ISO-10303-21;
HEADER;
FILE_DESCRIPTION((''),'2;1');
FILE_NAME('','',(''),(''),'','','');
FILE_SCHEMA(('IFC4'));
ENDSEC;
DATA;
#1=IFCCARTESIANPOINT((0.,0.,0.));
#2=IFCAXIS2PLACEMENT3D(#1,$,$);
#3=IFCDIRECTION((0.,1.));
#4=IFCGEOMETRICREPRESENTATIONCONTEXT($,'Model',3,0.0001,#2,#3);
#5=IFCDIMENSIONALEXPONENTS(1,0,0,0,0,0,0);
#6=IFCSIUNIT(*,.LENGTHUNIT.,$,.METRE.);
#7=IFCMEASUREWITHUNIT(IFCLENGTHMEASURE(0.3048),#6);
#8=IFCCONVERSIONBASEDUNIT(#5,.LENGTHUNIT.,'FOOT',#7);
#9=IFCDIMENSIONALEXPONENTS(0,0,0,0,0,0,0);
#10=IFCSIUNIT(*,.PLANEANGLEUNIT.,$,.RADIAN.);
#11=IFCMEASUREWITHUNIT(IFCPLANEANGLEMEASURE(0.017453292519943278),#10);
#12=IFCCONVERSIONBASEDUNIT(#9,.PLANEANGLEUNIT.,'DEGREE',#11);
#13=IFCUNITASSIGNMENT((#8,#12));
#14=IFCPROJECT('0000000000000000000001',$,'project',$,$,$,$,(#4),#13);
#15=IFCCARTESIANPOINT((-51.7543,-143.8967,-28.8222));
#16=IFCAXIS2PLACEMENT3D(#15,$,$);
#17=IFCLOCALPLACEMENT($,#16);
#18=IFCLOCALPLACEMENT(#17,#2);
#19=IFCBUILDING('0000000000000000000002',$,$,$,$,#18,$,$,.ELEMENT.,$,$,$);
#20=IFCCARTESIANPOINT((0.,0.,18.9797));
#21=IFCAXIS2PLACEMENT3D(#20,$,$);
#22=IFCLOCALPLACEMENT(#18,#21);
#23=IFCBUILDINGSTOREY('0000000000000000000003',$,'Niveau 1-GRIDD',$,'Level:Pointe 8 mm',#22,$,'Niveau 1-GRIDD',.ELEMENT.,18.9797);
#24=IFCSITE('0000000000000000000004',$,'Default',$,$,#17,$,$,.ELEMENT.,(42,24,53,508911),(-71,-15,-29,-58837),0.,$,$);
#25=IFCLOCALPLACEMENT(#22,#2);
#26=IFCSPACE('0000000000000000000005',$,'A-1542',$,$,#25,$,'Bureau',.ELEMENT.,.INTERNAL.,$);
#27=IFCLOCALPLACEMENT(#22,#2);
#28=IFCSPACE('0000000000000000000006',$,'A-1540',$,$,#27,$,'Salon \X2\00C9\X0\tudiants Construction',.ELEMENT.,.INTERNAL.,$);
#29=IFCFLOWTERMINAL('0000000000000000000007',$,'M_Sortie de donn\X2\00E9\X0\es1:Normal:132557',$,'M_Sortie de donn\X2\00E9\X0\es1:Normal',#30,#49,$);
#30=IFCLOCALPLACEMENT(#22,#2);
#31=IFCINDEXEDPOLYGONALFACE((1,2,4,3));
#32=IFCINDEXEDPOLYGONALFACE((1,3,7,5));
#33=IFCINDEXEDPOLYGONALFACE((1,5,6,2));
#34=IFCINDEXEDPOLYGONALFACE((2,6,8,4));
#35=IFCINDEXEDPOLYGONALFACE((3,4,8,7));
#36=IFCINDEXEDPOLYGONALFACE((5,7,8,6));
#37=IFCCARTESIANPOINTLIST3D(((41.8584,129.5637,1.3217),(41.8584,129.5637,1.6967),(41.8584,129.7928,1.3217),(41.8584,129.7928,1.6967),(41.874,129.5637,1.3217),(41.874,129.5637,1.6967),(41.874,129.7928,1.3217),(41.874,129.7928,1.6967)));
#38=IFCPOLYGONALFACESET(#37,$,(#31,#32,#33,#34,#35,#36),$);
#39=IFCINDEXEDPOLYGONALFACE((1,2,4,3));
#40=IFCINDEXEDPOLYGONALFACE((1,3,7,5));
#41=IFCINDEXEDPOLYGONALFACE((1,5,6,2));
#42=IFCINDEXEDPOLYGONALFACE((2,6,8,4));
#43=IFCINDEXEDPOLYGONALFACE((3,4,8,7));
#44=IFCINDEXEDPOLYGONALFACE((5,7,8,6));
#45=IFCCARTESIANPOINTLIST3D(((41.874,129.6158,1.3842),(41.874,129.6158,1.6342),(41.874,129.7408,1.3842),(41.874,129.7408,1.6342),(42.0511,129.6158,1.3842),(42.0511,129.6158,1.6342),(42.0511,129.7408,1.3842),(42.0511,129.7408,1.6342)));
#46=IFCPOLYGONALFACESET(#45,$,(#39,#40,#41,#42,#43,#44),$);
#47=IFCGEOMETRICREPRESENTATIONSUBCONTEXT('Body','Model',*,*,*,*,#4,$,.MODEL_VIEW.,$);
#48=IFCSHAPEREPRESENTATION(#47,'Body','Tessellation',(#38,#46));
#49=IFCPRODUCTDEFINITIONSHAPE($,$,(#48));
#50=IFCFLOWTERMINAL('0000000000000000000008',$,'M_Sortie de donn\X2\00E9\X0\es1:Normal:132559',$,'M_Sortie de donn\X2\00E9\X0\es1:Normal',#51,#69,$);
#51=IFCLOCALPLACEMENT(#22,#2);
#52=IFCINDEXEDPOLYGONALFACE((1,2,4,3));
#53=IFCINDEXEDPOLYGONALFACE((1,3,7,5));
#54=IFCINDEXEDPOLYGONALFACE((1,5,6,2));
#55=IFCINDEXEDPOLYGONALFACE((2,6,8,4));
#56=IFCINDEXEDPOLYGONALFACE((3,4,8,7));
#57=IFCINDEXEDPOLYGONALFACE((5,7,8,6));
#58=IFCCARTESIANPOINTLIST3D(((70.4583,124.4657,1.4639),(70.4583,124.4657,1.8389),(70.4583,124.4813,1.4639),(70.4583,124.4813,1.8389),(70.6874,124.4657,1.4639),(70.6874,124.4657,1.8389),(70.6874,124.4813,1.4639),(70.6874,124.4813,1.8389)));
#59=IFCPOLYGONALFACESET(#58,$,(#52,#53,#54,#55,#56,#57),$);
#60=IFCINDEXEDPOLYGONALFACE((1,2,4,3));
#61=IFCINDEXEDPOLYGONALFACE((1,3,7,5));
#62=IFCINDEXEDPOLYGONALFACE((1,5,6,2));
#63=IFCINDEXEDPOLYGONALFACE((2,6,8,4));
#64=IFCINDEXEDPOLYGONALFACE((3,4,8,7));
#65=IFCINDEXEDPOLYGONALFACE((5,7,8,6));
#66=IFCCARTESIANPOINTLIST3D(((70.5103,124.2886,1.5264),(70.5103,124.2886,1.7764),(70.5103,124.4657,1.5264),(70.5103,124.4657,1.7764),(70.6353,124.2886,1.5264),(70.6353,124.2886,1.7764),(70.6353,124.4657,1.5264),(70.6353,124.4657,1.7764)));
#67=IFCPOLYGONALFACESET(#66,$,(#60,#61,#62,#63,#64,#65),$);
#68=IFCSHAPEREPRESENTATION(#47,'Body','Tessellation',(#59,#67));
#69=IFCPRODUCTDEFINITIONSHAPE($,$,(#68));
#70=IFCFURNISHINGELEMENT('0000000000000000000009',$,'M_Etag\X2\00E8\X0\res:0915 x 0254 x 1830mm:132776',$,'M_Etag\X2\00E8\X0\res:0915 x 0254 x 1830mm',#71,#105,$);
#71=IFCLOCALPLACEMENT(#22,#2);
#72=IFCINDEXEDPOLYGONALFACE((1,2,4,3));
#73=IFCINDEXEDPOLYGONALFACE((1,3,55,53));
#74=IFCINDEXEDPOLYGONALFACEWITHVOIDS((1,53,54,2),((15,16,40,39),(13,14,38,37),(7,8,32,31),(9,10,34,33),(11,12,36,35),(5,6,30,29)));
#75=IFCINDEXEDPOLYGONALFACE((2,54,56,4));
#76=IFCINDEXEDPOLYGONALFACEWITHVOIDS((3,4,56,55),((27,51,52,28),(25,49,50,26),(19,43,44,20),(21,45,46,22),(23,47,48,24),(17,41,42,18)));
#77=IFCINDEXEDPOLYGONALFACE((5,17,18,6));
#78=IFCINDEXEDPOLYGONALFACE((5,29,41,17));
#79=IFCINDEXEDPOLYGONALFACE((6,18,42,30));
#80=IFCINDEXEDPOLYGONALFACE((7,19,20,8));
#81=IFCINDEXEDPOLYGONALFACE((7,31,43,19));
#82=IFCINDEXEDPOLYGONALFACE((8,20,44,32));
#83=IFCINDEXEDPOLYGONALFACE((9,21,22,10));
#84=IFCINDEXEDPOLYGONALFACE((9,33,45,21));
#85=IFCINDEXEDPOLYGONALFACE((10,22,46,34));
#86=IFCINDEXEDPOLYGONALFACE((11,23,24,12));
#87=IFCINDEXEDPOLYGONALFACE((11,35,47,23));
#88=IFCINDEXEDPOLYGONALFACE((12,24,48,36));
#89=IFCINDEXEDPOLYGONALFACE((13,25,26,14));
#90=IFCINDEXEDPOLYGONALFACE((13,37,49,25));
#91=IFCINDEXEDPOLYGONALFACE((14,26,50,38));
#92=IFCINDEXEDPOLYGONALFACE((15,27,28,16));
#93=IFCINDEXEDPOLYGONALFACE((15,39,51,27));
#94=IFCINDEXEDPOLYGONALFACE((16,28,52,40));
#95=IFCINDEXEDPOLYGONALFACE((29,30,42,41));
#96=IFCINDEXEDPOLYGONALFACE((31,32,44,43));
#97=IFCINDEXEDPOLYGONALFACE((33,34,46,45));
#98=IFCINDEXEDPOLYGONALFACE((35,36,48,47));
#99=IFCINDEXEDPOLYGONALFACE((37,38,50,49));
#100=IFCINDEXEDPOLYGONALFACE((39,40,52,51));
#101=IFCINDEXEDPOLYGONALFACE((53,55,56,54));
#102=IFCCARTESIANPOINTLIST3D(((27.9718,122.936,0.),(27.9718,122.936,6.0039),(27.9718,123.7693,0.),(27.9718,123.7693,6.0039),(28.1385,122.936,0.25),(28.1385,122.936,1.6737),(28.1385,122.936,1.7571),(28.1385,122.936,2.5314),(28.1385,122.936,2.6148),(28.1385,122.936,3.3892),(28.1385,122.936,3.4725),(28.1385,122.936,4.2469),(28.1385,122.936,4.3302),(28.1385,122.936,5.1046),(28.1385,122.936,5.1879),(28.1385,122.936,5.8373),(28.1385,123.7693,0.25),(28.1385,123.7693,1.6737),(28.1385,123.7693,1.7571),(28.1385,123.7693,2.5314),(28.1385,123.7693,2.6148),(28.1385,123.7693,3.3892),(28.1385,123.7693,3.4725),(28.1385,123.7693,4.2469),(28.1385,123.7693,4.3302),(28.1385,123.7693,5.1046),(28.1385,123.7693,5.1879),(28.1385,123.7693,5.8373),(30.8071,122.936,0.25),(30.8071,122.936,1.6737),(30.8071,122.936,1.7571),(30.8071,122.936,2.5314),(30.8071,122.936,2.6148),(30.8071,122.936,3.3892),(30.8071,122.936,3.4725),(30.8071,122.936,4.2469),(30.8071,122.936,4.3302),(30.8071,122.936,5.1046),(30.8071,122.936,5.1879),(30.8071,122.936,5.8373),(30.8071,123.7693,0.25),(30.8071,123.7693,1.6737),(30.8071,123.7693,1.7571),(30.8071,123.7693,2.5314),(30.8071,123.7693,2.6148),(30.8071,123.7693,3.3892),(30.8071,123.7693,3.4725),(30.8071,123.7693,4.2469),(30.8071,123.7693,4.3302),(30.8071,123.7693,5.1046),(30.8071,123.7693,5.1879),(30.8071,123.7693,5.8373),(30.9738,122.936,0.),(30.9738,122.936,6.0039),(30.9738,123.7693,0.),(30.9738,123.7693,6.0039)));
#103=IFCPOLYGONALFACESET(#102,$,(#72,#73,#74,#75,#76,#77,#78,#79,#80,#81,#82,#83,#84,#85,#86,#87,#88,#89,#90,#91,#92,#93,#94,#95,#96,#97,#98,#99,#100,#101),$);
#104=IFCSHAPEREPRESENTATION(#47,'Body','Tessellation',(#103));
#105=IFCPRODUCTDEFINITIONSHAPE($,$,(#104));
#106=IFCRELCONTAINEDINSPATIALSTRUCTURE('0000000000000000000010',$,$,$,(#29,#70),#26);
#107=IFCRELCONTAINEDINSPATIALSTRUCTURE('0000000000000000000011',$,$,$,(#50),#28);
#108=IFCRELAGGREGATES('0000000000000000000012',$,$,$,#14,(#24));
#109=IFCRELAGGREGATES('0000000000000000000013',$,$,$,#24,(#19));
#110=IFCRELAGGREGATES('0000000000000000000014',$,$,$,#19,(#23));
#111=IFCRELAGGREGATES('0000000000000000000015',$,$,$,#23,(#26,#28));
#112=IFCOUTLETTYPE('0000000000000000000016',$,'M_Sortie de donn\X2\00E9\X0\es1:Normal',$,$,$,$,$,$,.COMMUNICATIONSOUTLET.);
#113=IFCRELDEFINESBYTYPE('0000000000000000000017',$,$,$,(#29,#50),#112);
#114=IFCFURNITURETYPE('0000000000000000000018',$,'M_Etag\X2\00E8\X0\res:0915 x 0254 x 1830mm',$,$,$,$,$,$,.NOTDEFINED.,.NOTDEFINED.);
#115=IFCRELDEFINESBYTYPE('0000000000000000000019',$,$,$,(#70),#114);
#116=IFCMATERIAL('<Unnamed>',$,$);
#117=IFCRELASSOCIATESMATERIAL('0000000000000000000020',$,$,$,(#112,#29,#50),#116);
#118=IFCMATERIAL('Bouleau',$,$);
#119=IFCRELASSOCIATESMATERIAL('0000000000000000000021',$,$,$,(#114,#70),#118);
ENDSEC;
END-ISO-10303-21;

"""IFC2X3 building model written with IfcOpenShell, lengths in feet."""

from ifc_helpers import new_model, entity, si_unit, converted_unit, direction, frame, frame_2d, origin, place, context, subcontext, project, spatial, polyline, rectangle, outline, extrude, source, transform, mapped, material, type_object, type_shapes, element, save


model = new_model("IFC2X3")

# Units and contexts
model_context = context("Model", 3, precision=0.0001, world=origin(), true_north=direction((0.0, 1.0)))
body_context = subcontext(model_context, "Body", "Model", "MODEL_VIEW")
ifc_project = project(units=[converted_unit("LENGTHUNIT", "FOOT", entity("IfcLengthMeasure", 0.3048), si_unit("LENGTHUNIT", "METRE"), dimensions=[1, 0, 0, 0, 0, 0, 0]), converted_unit("PLANEANGLEUNIT", "DEGREE", entity("IfcPlaneAngleMeasure", 0.017453292519943278), si_unit("PLANEANGLEUNIT", "RADIAN"), dimensions=[0, 0, 0, 0, 0, 0, 0])], contexts=[model_context])

# Site, building, storey
site_placement = place(None, frame((-51.7543, -143.8967, -28.8222)))
site = spatial("IfcSite", under=ifc_project, at=site_placement, Name="Default", CompositionType="ELEMENT", RefLatitude=(42, 24, 53, 508911), RefLongitude=(-71, -15, -29, -58837), RefElevation=0.0)
building_placement = place(site_placement, origin())
building = spatial("IfcBuilding", under=site, at=building_placement, CompositionType="ELEMENT")
storey_placement = place(building_placement, frame((0.0, 0.0, 18.9797)))
storey = spatial("IfcBuildingStorey", under=building, at=storey_placement, Name="Niveau 1-GRIDD", ObjectType="Level:Pointe 8 mm", LongName="Niveau 1-GRIDD", CompositionType="ELEMENT", Elevation=18.9797)

# Shared definitions
space_1_placement = place(storey_placement, origin())
space_1 = spatial("IfcSpace", under=storey, at=space_1_placement, Name="A-1542", LongName="Bureau", CompositionType="ELEMENT", InteriorOrExteriorSpace="INTERNAL")

# Flow terminal
ifc_material_1 = material(Name="<Unnamed>")
outlet_type = type_object("IfcOutletType", Name="M_Sortie de données1:Normal", PredefinedType="COMMUNICATIONSOUTLET", material=ifc_material_1)
shared_shape_1 = source(origin(), body_context, "Body", "SweptSolid", [
    extrude(rectangle(XDim=0.2292, YDim=0.375, at=frame_2d((0.0, 0.0), x_axis=(1.0, 0.0))), frame((0.0, 0.0, 0.0), z_axis=(0.0, 0.0, 1.0), x_axis=(-1.0, 0.0, 0.0)), (0.0, 0.0, 1.0), 0.0156),
    extrude(rectangle(XDim=0.125, YDim=0.25, at=frame_2d((0.0, 0.0), x_axis=(1.0, 0.0))), frame((0.0, 0.0, -0.1771), z_axis=(0.0, 0.0, 1.0), x_axis=(-1.0, 0.0, 0.0)), (0.0, 0.0, 1.0), 0.1771),
])
type_shapes(outlet_type, [shared_shape_1])
for number, where, z_axis, x_axis, name in (
    (1, (41.874, 129.6783, 1.5092), (-1.0, 0.0, 0.0), (0.0, -1.0, 0.0), "M_Sortie de données1:Normal:132557"),
):
    element("IfcFlowTerminal", number, at=place(space_1_placement, frame(where, z_axis=z_axis, x_axis=x_axis)), inside=space_1, type_object=outlet_type, material=ifc_material_1, Name=name, ObjectType="M_Sortie de données1:Normal", context=body_context, shape_type="MappedRepresentation", body=[
        mapped(shared_shape_1, transform((0.0, 0.0, 0.0), scale=1.0)),
    ])

# Shared definitions
space_2_placement = place(storey_placement, origin())
space_2 = spatial("IfcSpace", under=storey, at=space_2_placement, Name="A-1540", LongName="Salon Étudiants Construction", CompositionType="ELEMENT", InteriorOrExteriorSpace="INTERNAL")

# Flow terminal
flow_terminal_placement = place(space_2_placement, frame((70.5728, 124.4657, 1.6514), z_axis=(0.0, 1.0, 0.0), x_axis=(-1.0, 0.0, 0.0)))
element("IfcFlowTerminal", 2, at=flow_terminal_placement, inside=space_2, type_object=outlet_type, material=ifc_material_1, Name="M_Sortie de données1:Normal:132559", ObjectType="M_Sortie de données1:Normal", context=body_context, shape_type="MappedRepresentation", body=[
    mapped(shared_shape_1, transform((0.0, 0.0, 0.0), scale=1.0)),
])

# Furnishing element
ifc_material_2 = material(Name="Bouleau")
furniture_type_1 = type_object("IfcFurnitureType", Name="M_Etagères:0915 x 0254 x 1830mm", AssemblyPlace="NOTDEFINED", material=ifc_material_2)
shared_shape_2 = source(origin(), body_context, "Body", "SweptSolid", [
    extrude(outline(polyline([(-1.501, -3.002), (1.501, -3.002), (1.501, 3.002), (-1.501, 3.002), (-1.501, -3.002)]), holes=[polyline([(-1.3343, 2.8353), (1.3343, 2.8353), (1.3343, 2.1859), (-1.3343, 2.1859), (-1.3343, 2.8353)]), polyline([(-1.3343, -2.752), (-1.3343, -1.3282), (1.3343, -1.3282), (1.3343, -2.752), (-1.3343, -2.752)]), polyline([(1.3343, 0.4705), (-1.3343, 0.4705), (-1.3343, 1.2449), (1.3343, 1.2449), (1.3343, 0.4705)]), polyline([(-1.3343, 2.1026), (1.3343, 2.1026), (1.3343, 1.3282), (-1.3343, 1.3282), (-1.3343, 2.1026)]), polyline([(-1.3343, 0.3872), (1.3343, 0.3872), (1.3343, -0.3872), (-1.3343, -0.3872), (-1.3343, 0.3872)]), polyline([(-1.3343, -0.4705), (1.3343, -0.4705), (1.3343, -1.2449), (-1.3343, -1.2449), (-1.3343, -0.4705)])]), frame((0.0, -1.4167, 3.002), z_axis=(0.0, 1.0, 0.0), x_axis=(-1.0, 0.0, 0.0)), (0.0, 0.0, 1.0), 0.8333),
])
type_shapes(furniture_type_1, [shared_shape_2])
furnishing_1_placement = place(space_1_placement, frame((29.4728, 124.3527, 0.0)))
element("IfcFurnishingElement", 3, at=furnishing_1_placement, inside=space_1, type_object=furniture_type_1, material=ifc_material_2, Name="M_Etagères:0915 x 0254 x 1830mm:132776", ObjectType="M_Etagères:0915 x 0254 x 1830mm", context=body_context, shape_type="MappedRepresentation", body=[
    mapped(shared_shape_2, transform((0.0, 0.0, 0.0), scale=1.0)),
])

save(model, "model.ifc")
